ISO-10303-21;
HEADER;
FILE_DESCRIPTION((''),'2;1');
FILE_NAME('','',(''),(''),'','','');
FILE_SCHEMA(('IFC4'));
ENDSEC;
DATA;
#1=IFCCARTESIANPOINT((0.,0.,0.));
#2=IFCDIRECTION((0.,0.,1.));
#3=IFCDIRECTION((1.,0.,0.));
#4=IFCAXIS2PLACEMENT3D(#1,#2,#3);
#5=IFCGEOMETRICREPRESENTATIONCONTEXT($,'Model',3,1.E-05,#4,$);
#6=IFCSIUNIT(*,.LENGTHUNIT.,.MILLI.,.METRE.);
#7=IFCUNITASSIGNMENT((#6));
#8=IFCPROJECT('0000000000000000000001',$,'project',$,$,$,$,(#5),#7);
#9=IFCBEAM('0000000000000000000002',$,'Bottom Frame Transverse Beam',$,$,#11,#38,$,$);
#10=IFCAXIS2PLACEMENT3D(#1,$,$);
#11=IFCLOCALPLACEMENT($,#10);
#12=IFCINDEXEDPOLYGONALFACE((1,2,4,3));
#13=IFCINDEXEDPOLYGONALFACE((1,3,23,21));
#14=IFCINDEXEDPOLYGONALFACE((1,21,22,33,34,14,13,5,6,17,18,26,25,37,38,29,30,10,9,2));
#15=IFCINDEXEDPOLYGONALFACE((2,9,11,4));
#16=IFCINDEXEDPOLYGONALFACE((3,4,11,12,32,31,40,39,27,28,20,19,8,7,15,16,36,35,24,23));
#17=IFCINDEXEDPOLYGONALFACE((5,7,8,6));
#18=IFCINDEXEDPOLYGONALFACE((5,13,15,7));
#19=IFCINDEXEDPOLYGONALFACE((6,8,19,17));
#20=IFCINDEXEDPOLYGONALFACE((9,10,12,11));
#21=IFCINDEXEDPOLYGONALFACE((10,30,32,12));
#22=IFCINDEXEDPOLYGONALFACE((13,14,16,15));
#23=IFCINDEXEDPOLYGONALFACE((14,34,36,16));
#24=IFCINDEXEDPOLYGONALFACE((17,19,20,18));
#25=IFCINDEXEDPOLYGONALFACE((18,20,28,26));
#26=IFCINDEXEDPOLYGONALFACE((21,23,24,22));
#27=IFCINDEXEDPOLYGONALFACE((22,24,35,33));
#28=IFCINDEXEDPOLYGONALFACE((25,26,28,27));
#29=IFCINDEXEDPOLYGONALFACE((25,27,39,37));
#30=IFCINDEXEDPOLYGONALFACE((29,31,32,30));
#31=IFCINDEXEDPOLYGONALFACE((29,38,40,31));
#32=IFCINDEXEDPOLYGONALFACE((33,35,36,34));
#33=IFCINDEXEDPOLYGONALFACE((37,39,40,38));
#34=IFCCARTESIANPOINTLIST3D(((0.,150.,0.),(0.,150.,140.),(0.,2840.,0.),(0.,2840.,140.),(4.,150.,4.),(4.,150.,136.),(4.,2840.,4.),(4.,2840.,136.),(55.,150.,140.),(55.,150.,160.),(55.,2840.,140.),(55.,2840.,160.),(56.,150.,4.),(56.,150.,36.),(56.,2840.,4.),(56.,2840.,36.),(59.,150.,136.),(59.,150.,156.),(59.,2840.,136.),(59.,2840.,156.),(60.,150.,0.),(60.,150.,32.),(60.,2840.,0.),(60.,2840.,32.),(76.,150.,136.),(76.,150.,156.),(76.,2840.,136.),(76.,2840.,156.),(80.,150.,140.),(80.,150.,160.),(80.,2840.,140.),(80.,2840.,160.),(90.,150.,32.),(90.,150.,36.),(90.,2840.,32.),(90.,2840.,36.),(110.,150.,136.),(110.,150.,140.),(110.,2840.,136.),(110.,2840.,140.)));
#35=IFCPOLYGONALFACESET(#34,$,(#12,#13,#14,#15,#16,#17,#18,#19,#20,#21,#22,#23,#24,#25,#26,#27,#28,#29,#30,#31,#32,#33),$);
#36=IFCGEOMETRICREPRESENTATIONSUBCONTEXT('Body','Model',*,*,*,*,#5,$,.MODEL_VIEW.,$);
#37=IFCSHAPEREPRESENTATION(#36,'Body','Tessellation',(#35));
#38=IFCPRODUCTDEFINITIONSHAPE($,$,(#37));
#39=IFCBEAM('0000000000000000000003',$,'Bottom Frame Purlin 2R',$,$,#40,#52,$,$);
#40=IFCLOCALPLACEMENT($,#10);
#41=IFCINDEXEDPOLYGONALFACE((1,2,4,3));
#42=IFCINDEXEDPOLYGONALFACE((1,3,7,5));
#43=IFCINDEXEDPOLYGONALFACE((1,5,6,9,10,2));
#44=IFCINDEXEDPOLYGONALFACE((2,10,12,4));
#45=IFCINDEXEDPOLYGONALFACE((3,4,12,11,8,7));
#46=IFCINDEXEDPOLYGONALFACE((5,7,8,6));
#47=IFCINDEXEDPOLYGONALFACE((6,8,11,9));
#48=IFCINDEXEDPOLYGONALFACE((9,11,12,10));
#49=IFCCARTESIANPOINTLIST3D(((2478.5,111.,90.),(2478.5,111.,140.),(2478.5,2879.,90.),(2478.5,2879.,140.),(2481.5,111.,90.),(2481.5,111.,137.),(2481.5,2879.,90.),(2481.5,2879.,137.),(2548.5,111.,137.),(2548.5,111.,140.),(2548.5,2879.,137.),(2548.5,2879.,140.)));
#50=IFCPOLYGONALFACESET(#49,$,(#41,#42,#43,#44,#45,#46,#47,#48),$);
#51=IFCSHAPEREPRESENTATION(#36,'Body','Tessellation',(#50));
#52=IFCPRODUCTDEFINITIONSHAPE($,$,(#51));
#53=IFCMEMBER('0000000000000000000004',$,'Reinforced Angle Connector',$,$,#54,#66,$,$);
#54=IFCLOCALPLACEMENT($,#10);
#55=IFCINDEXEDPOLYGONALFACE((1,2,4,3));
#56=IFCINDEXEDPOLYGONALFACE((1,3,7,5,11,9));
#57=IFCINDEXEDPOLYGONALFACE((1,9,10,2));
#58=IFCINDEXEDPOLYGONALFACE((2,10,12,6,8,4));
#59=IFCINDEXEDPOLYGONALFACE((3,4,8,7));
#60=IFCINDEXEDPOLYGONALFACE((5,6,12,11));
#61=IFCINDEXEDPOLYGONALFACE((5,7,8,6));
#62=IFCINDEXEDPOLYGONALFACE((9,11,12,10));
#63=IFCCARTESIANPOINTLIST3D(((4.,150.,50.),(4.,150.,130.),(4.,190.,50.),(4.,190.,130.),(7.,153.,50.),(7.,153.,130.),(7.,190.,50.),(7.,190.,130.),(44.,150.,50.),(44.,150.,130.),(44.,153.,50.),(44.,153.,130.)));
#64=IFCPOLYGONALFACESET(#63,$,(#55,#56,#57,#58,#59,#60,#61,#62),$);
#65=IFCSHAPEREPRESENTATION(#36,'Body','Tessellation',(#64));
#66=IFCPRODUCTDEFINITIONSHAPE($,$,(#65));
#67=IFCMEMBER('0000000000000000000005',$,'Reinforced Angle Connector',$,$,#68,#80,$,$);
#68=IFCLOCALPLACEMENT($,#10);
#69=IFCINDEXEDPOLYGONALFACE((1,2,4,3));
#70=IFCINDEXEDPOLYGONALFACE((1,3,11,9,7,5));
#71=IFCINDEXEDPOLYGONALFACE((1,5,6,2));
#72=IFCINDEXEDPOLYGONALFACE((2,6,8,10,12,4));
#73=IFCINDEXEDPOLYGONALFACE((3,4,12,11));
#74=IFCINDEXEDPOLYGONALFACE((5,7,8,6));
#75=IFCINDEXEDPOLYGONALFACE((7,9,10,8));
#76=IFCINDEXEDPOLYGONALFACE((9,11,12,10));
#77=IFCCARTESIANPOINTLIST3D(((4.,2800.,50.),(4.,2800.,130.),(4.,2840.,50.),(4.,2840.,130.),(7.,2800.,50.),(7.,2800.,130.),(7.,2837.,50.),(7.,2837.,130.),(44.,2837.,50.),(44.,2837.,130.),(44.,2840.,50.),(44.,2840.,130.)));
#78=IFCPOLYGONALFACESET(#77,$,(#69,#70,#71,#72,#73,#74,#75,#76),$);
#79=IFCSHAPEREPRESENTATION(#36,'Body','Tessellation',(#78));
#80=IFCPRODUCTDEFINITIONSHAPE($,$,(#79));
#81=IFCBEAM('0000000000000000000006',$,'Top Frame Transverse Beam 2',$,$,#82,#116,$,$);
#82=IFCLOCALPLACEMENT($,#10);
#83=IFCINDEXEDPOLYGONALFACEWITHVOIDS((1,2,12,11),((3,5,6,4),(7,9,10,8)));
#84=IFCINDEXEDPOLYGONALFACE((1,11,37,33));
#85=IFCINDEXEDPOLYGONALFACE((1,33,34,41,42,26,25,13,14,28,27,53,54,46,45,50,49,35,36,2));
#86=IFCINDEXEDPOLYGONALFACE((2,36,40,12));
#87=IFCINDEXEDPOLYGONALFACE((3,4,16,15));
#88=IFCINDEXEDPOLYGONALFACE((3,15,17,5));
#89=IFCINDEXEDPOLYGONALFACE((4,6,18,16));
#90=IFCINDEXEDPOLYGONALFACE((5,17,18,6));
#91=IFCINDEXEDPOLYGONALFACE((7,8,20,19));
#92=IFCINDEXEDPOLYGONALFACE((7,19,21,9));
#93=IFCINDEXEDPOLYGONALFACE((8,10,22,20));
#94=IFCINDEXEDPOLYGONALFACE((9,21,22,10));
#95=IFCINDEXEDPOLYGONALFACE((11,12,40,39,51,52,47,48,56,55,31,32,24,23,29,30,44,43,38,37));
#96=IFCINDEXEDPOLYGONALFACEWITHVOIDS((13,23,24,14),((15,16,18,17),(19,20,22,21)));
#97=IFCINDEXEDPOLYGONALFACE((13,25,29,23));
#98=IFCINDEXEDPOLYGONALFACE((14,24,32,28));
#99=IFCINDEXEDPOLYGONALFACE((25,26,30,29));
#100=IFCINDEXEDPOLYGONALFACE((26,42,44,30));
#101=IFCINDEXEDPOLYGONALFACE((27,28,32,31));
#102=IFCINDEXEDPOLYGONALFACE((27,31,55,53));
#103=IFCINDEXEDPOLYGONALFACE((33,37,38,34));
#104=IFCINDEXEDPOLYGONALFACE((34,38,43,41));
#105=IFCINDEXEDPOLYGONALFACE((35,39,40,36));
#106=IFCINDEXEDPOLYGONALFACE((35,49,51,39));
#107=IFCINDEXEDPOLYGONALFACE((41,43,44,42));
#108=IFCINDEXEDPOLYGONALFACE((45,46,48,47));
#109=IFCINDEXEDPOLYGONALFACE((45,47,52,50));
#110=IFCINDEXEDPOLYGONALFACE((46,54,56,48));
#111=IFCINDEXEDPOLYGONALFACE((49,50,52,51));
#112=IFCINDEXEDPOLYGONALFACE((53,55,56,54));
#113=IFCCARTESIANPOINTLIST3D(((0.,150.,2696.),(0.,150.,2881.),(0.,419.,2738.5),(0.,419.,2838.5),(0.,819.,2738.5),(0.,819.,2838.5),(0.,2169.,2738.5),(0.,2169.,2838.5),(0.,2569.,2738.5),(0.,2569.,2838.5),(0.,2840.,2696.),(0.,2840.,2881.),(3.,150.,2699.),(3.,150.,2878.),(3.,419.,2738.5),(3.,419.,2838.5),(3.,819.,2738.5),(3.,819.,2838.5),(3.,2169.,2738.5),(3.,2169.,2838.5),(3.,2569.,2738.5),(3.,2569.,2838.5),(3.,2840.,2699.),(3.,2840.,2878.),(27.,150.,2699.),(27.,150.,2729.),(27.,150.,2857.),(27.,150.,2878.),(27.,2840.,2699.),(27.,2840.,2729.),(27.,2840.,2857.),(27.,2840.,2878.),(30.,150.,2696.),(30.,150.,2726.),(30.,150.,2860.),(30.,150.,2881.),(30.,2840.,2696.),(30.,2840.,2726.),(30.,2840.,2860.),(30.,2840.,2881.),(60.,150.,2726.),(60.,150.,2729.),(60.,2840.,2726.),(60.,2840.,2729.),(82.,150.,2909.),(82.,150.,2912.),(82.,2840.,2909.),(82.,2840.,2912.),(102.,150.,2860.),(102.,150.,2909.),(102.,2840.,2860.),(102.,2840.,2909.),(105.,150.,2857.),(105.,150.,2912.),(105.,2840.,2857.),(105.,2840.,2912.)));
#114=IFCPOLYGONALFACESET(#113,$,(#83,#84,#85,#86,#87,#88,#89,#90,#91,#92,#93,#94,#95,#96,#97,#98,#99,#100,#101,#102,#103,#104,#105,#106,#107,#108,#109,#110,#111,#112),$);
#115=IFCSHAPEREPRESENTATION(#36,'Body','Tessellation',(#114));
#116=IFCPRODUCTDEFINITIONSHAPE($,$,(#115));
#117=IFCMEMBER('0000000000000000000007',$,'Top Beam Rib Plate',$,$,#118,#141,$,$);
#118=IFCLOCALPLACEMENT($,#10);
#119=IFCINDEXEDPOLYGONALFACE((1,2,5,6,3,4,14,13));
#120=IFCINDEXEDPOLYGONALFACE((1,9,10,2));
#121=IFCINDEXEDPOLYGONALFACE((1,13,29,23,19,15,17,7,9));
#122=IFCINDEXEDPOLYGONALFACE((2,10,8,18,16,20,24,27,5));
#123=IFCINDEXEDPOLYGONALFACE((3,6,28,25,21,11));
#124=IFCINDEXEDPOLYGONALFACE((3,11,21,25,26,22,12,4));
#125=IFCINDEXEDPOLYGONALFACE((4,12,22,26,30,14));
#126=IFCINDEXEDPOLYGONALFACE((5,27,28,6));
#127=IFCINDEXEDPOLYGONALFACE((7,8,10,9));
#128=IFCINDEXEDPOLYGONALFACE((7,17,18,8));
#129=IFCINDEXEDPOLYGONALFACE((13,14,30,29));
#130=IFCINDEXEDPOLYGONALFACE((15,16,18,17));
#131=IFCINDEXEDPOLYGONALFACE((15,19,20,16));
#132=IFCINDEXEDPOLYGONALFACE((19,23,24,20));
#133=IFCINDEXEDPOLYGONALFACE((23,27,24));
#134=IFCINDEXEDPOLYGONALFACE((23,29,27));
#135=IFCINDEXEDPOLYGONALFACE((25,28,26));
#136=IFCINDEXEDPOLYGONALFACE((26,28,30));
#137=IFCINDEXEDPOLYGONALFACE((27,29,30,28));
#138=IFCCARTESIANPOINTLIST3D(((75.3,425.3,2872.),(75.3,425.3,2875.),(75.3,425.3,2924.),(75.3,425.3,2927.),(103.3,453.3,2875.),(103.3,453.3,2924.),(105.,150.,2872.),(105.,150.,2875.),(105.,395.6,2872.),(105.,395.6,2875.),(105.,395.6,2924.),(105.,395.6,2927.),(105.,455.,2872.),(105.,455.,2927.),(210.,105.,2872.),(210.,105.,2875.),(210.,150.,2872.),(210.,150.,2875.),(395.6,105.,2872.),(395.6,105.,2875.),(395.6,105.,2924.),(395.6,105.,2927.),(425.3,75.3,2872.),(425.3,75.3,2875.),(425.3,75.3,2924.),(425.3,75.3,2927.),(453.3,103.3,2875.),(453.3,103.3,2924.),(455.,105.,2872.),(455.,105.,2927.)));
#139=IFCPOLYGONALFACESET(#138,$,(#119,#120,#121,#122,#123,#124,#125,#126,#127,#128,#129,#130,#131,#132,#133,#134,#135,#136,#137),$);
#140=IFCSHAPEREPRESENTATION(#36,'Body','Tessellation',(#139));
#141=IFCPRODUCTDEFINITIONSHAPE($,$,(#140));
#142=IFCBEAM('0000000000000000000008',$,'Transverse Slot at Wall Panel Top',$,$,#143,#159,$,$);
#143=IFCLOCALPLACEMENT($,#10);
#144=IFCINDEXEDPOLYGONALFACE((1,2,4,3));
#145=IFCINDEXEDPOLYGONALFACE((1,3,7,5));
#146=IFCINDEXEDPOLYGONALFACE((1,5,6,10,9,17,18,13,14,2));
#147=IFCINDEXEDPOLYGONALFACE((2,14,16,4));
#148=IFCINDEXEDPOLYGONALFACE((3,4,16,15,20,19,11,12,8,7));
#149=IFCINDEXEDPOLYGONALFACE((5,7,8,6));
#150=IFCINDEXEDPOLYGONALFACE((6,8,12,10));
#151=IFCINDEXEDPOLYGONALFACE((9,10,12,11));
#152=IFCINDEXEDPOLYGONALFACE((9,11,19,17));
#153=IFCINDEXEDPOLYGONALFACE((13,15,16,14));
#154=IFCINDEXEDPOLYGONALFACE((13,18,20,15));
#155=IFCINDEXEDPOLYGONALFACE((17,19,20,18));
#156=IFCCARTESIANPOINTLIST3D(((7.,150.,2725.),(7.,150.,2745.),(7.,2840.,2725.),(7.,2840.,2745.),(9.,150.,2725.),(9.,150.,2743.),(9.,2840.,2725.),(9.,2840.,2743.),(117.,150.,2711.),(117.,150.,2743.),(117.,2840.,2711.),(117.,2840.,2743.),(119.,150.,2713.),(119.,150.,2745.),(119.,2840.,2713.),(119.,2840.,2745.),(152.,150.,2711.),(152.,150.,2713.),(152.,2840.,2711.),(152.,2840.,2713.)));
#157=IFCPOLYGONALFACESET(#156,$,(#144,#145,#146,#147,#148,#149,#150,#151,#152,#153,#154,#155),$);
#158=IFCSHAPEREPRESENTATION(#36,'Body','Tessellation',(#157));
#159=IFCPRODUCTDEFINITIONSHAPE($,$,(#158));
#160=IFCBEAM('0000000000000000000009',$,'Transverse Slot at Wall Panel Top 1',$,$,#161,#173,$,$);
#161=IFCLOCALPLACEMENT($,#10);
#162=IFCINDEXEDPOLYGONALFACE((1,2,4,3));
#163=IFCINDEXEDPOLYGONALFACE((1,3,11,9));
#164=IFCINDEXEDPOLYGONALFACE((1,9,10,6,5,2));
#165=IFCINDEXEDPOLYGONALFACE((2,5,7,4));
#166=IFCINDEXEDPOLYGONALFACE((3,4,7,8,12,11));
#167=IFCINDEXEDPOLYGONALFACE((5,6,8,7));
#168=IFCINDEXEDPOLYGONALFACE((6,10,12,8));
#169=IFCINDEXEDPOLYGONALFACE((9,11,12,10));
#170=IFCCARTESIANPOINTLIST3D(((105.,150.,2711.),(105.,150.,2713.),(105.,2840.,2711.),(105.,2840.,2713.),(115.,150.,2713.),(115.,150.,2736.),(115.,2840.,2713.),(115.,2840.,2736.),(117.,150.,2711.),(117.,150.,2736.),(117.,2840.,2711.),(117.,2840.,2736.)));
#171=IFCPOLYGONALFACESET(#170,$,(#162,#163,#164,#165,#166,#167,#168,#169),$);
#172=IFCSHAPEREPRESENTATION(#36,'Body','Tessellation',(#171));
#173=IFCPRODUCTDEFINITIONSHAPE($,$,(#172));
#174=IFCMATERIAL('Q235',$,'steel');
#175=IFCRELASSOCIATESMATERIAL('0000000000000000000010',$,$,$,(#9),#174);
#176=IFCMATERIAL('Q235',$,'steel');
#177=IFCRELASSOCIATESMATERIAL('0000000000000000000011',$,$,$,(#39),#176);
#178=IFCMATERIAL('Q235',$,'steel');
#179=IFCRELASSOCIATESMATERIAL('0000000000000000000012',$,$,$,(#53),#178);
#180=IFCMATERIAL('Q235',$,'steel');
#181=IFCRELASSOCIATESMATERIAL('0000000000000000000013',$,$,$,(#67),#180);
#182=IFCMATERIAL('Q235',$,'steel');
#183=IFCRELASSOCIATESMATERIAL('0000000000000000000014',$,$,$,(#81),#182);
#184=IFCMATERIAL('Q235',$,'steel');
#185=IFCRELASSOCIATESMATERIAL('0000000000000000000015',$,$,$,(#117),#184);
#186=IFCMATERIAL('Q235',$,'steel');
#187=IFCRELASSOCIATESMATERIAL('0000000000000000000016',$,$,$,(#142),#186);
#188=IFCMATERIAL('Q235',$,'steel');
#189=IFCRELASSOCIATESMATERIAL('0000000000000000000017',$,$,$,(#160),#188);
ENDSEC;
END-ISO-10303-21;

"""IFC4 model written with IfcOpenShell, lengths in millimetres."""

from ifc_helpers import new_model, si_unit, frame, origin_with_axes, place, context, subcontext, project, line, indexed_curve, outline, extrude, material, element, save


model = new_model("IFC4")

# Units and contexts
model_context = context("Model", 3, precision=1e-05, world=origin_with_axes())
body_context = subcontext(model_context, "Body", "Model", "MODEL_VIEW")
ifc_project = project(units=[si_unit("LENGTHUNIT", "METRE", prefix="MILLI")], contexts=[model_context])

# Beams
ifc_material_1 = material(Name="Q235", Category="steel")
beam_1_placement = place(None, frame((0.0, 150.0, 0.0), z_axis=(0.0, 1.0, 0.0), x_axis=(1.0, 0.0, 0.0)))
element("IfcBeam", 1, at=beam_1_placement, material=ifc_material_1, Name="Bottom Frame Transverse Beam", context=body_context, shape_type="SweptSolid", body=[
    extrude(outline(indexed_curve([(0.0, 0.0), (60.0, 0.0), (60.0, -32.0), (90.0, -32.0), (90.0, -36.0), (56.0, -36.0), (56.0, -4.0), (4.0, -4.0), (4.0, -136.0), (59.0, -136.0), (59.0, -156.0), (76.0, -156.0), (76.0, -136.0), (110.0, -136.0), (110.0, -140.0), (80.0, -140.0), (80.0, -160.0), (55.0, -160.0), (55.0, -140.0), (0.0, -140.0), (0.0, 0.0)], segments=[line(1, 2, 3, 4, 5, 6, 7, 8, 9, 10, 11, 12, 13, 14, 15, 16, 17, 18, 19, 20, 21, 1)])), origin_with_axes(), (0.0, 0.0, 1.0), 2690.0),
])
ifc_material_2 = material(Name="Q235", Category="steel")
beam_2_placement = place(None, frame((2478.5, 111.0, 140.0), z_axis=(0.0, 1.0, 0.0), x_axis=(1.0, 0.0, 0.0)))
element("IfcBeam", 2, at=beam_2_placement, material=ifc_material_2, Name="Bottom Frame Purlin 2R", context=body_context, shape_type="SweptSolid", body=[
    extrude(outline(indexed_curve([(0.0, 0.0), (0.0, 50.0), (3.0, 50.0), (3.0, 3.0), (70.0, 3.0), (70.0, 0.0), (0.0, 0.0)], segments=[line(1, 2, 3, 4, 5, 6, 7, 1)])), origin_with_axes(), (0.0, 0.0, 1.0), 2768.0),
])

# Members
ifc_material_3 = material(Name="Q235", Category="steel")
member_1_placement = place(None, frame((4.0, 150.0, 50.0), z_axis=(0.0, 0.0, 1.0), x_axis=(1.0, 0.0, 0.0)))
element("IfcMember", 3, at=member_1_placement, material=ifc_material_3, Name="Reinforced Angle Connector", context=body_context, shape_type="SweptSolid", body=[
    extrude(outline(indexed_curve([(0.0, 0.0), (0.0, 40.0), (3.0, 40.0), (3.0, 3.0), (40.0, 3.0), (40.0, 0.0), (0.0, 0.0)], segments=[line(1, 2, 3, 4, 5, 6, 7, 1)])), origin_with_axes(), (0.0, 0.0, 1.0), 80.0),
])
ifc_material_4 = material(Name="Q235", Category="steel")
member_2_placement = place(None, frame((4.0, 2840.0, 50.0), z_axis=(0.0, 0.0, 1.0), x_axis=(0.0, -1.0, 0.0)))
element("IfcMember", 4, at=member_2_placement, material=ifc_material_4, Name="Reinforced Angle Connector", context=body_context, shape_type="SweptSolid", body=[
    extrude(outline(indexed_curve([(0.0, 0.0), (0.0, 40.0), (3.0, 40.0), (3.0, 3.0), (40.0, 3.0), (40.0, 0.0), (0.0, 0.0)], segments=[line(1, 2, 3, 4, 5, 6, 7, 1)])), origin_with_axes(), (0.0, 0.0, 1.0), 80.0),
])

# Beam, openings
ifc_material_5 = material(Name="Q235", Category="steel")
beam_3_placement = place(None, frame((0.0, 150.0, 2696.0), z_axis=(0.0, 1.0, 0.0), x_axis=(1.0, 0.0, 0.0)))
beam_3 = element("IfcBeam", 5, at=beam_3_placement, material=ifc_material_5, Name="Top Frame Transverse Beam 2", context=body_context, shape_type="SweptSolid", body=[
    extrude(outline(indexed_curve([(60.0, -30.0), (30.0, -30.0), (30.0, 0.0), (0.0, 0.0), (0.0, -185.0), (30.0, -185.0), (30.0, -164.0), (102.0, -164.0), (102.0, -213.0), (82.0, -213.0), (82.0, -216.0), (105.0, -216.0), (105.0, -161.0), (27.0, -161.0), (27.0, -182.0), (3.0, -182.0), (3.0, -3.0), (27.0, -3.0), (27.0, -33.0), (60.0, -33.0), (60.0, -30.0)], segments=[line(1, 2, 3, 4, 5, 6, 7, 8, 9, 10, 11, 12, 13, 14, 15, 16, 17, 18, 19, 20, 21, 1)])), origin_with_axes(), (0.0, 0.0, 1.0), 2690.0),
])
opening_1_placement = place(beam_3_placement, frame((0.0, -42.5, 669.0), z_axis=(1.0, 0.0, 0.0), x_axis=(0.0, 0.0, -1.0)))
element("IfcOpeningElement", 6, at=opening_1_placement, cuts=beam_3, context=body_context, shape_type="SweptSolid", body=[
    extrude(outline(indexed_curve([(0.0, 0.0), (0.0, -100.0), (400.0, -100.0), (400.0, 0.0), (0.0, 0.0)], segments=[line(1, 2, 3, 4, 5, 1)])), origin_with_axes(), (0.0, 0.0, 1.0), 4.0),
])
opening_2_placement = place(beam_3_placement, frame((0.0, -42.5, 2419.0), z_axis=(1.0, 0.0, 0.0), x_axis=(0.0, 0.0, -1.0)))
element("IfcOpeningElement", 7, at=opening_2_placement, cuts=beam_3, context=body_context, shape_type="SweptSolid", body=[
    extrude(outline(indexed_curve([(0.0, 0.0), (0.0, -100.0), (400.0, -100.0), (400.0, 0.0), (0.0, 0.0)], segments=[line(1, 2, 3, 4, 5, 1)])), origin_with_axes(), (0.0, 0.0, 1.0), 4.0),
])

# Member, openings
ifc_material_6 = material(Name="Q235", Category="steel")
member_3_placement = place(None, frame((210.0, 150.0, 2872.0), z_axis=(0.0, 0.0, 1.0), x_axis=(1.0, 0.0, 0.0)))
member_3 = element("IfcMember", 8, at=member_3_placement, material=ifc_material_6, Name="Top Beam Rib Plate", context=body_context, shape_type="SweptSolid", body=[
    extrude(outline(indexed_curve([(0.0, 0.0), (0.0, -45.0), (185.6, -45.0), (215.3, -74.7), (245.0, -45.0), (-105.0, 305.0), (-134.7, 275.3), (-105.0, 245.6), (-105.0, 0.0), (0.0, 0.0)], segments=[line(1, 2, 3, 4, 5, 6, 7, 8, 9, 10, 1)])), origin_with_axes(), (0.0, 0.0, 1.0), 55.0),
])
opening_3_placement = place(member_3_placement, frame((0.0, 0.0, 3.0), z_axis=(0.0, 0.0, 1.0), x_axis=(1.0, 0.0, 0.0)))
element("IfcOpeningElement", 9, at=opening_3_placement, cuts=member_3, context=body_context, shape_type="SweptSolid", body=[
    extrude(outline(indexed_curve([(0.0, 0.0), (0.0, -45.0), (185.6, -45.0), (-105.0, 245.6), (-105.0, 0.0), (0.0, 0.0)], segments=[line(1, 2, 3, 4, 5, 6, 1)])), origin_with_axes(), (0.0, 0.0, 1.0), 55.0),
])
opening_4_placement = place(member_3_placement, frame((0.0, 0.0, 3.0), z_axis=(0.0, 0.0, 1.0), x_axis=(1.0, 0.0, 0.0)))
element("IfcOpeningElement", 10, at=opening_4_placement, cuts=member_3, context=body_context, shape_type="SweptSolid", body=[
    extrude(outline(indexed_curve([(215.3, -74.7), (243.3, -46.7), (-106.7, 303.3), (-134.7, 275.3)], segments=[line(1, 2, 3, 4, 1)])), origin_with_axes(), (0.0, 0.0, 1.0), 49.0),
])

# Beams
ifc_material_7 = material(Name="Q235", Category="steel")
beam_4_placement = place(None, frame((0.0, 150.0, 2711.0), z_axis=(0.0, 1.0, 0.0), x_axis=(1.0, 0.0, 0.0)))
element("IfcBeam", 11, at=beam_4_placement, material=ifc_material_7, Name="Transverse Slot at Wall Panel Top", context=body_context, shape_type="SweptSolid", body=[
    extrude(outline(indexed_curve([(152.0, 0.0), (117.0, 0.0), (117.0, -32.0), (9.0, -32.0), (9.0, -14.0), (7.0, -14.0), (7.0, -34.0), (119.0, -34.0), (119.0, -2.0), (152.0, -2.0), (152.0, 0.0)], segments=[line(1, 2, 3, 4, 5, 6, 7, 8, 9, 10, 11, 1)])), origin_with_axes(), (0.0, 0.0, 1.0), 2690.0),
])
ifc_material_8 = material(Name="Q235", Category="steel")
beam_5_placement = place(None, frame((0.0, 150.0, 2711.0), z_axis=(0.0, 1.0, 0.0), x_axis=(1.0, 0.0, 0.0)))
element("IfcBeam", 12, at=beam_5_placement, material=ifc_material_8, Name="Transverse Slot at Wall Panel Top 1", context=body_context, shape_type="SweptSolid", body=[
    extrude(outline(indexed_curve([(117.0, 0.0), (105.0, 0.0), (105.0, -2.0), (115.0, -2.0), (115.0, -25.0), (117.0, -25.0), (117.0, 0.0)], segments=[line(1, 2, 3, 4, 5, 6, 7, 1)])), origin_with_axes(), (0.0, 0.0, 1.0), 2690.0),
])

save(model, "model.ifc")
